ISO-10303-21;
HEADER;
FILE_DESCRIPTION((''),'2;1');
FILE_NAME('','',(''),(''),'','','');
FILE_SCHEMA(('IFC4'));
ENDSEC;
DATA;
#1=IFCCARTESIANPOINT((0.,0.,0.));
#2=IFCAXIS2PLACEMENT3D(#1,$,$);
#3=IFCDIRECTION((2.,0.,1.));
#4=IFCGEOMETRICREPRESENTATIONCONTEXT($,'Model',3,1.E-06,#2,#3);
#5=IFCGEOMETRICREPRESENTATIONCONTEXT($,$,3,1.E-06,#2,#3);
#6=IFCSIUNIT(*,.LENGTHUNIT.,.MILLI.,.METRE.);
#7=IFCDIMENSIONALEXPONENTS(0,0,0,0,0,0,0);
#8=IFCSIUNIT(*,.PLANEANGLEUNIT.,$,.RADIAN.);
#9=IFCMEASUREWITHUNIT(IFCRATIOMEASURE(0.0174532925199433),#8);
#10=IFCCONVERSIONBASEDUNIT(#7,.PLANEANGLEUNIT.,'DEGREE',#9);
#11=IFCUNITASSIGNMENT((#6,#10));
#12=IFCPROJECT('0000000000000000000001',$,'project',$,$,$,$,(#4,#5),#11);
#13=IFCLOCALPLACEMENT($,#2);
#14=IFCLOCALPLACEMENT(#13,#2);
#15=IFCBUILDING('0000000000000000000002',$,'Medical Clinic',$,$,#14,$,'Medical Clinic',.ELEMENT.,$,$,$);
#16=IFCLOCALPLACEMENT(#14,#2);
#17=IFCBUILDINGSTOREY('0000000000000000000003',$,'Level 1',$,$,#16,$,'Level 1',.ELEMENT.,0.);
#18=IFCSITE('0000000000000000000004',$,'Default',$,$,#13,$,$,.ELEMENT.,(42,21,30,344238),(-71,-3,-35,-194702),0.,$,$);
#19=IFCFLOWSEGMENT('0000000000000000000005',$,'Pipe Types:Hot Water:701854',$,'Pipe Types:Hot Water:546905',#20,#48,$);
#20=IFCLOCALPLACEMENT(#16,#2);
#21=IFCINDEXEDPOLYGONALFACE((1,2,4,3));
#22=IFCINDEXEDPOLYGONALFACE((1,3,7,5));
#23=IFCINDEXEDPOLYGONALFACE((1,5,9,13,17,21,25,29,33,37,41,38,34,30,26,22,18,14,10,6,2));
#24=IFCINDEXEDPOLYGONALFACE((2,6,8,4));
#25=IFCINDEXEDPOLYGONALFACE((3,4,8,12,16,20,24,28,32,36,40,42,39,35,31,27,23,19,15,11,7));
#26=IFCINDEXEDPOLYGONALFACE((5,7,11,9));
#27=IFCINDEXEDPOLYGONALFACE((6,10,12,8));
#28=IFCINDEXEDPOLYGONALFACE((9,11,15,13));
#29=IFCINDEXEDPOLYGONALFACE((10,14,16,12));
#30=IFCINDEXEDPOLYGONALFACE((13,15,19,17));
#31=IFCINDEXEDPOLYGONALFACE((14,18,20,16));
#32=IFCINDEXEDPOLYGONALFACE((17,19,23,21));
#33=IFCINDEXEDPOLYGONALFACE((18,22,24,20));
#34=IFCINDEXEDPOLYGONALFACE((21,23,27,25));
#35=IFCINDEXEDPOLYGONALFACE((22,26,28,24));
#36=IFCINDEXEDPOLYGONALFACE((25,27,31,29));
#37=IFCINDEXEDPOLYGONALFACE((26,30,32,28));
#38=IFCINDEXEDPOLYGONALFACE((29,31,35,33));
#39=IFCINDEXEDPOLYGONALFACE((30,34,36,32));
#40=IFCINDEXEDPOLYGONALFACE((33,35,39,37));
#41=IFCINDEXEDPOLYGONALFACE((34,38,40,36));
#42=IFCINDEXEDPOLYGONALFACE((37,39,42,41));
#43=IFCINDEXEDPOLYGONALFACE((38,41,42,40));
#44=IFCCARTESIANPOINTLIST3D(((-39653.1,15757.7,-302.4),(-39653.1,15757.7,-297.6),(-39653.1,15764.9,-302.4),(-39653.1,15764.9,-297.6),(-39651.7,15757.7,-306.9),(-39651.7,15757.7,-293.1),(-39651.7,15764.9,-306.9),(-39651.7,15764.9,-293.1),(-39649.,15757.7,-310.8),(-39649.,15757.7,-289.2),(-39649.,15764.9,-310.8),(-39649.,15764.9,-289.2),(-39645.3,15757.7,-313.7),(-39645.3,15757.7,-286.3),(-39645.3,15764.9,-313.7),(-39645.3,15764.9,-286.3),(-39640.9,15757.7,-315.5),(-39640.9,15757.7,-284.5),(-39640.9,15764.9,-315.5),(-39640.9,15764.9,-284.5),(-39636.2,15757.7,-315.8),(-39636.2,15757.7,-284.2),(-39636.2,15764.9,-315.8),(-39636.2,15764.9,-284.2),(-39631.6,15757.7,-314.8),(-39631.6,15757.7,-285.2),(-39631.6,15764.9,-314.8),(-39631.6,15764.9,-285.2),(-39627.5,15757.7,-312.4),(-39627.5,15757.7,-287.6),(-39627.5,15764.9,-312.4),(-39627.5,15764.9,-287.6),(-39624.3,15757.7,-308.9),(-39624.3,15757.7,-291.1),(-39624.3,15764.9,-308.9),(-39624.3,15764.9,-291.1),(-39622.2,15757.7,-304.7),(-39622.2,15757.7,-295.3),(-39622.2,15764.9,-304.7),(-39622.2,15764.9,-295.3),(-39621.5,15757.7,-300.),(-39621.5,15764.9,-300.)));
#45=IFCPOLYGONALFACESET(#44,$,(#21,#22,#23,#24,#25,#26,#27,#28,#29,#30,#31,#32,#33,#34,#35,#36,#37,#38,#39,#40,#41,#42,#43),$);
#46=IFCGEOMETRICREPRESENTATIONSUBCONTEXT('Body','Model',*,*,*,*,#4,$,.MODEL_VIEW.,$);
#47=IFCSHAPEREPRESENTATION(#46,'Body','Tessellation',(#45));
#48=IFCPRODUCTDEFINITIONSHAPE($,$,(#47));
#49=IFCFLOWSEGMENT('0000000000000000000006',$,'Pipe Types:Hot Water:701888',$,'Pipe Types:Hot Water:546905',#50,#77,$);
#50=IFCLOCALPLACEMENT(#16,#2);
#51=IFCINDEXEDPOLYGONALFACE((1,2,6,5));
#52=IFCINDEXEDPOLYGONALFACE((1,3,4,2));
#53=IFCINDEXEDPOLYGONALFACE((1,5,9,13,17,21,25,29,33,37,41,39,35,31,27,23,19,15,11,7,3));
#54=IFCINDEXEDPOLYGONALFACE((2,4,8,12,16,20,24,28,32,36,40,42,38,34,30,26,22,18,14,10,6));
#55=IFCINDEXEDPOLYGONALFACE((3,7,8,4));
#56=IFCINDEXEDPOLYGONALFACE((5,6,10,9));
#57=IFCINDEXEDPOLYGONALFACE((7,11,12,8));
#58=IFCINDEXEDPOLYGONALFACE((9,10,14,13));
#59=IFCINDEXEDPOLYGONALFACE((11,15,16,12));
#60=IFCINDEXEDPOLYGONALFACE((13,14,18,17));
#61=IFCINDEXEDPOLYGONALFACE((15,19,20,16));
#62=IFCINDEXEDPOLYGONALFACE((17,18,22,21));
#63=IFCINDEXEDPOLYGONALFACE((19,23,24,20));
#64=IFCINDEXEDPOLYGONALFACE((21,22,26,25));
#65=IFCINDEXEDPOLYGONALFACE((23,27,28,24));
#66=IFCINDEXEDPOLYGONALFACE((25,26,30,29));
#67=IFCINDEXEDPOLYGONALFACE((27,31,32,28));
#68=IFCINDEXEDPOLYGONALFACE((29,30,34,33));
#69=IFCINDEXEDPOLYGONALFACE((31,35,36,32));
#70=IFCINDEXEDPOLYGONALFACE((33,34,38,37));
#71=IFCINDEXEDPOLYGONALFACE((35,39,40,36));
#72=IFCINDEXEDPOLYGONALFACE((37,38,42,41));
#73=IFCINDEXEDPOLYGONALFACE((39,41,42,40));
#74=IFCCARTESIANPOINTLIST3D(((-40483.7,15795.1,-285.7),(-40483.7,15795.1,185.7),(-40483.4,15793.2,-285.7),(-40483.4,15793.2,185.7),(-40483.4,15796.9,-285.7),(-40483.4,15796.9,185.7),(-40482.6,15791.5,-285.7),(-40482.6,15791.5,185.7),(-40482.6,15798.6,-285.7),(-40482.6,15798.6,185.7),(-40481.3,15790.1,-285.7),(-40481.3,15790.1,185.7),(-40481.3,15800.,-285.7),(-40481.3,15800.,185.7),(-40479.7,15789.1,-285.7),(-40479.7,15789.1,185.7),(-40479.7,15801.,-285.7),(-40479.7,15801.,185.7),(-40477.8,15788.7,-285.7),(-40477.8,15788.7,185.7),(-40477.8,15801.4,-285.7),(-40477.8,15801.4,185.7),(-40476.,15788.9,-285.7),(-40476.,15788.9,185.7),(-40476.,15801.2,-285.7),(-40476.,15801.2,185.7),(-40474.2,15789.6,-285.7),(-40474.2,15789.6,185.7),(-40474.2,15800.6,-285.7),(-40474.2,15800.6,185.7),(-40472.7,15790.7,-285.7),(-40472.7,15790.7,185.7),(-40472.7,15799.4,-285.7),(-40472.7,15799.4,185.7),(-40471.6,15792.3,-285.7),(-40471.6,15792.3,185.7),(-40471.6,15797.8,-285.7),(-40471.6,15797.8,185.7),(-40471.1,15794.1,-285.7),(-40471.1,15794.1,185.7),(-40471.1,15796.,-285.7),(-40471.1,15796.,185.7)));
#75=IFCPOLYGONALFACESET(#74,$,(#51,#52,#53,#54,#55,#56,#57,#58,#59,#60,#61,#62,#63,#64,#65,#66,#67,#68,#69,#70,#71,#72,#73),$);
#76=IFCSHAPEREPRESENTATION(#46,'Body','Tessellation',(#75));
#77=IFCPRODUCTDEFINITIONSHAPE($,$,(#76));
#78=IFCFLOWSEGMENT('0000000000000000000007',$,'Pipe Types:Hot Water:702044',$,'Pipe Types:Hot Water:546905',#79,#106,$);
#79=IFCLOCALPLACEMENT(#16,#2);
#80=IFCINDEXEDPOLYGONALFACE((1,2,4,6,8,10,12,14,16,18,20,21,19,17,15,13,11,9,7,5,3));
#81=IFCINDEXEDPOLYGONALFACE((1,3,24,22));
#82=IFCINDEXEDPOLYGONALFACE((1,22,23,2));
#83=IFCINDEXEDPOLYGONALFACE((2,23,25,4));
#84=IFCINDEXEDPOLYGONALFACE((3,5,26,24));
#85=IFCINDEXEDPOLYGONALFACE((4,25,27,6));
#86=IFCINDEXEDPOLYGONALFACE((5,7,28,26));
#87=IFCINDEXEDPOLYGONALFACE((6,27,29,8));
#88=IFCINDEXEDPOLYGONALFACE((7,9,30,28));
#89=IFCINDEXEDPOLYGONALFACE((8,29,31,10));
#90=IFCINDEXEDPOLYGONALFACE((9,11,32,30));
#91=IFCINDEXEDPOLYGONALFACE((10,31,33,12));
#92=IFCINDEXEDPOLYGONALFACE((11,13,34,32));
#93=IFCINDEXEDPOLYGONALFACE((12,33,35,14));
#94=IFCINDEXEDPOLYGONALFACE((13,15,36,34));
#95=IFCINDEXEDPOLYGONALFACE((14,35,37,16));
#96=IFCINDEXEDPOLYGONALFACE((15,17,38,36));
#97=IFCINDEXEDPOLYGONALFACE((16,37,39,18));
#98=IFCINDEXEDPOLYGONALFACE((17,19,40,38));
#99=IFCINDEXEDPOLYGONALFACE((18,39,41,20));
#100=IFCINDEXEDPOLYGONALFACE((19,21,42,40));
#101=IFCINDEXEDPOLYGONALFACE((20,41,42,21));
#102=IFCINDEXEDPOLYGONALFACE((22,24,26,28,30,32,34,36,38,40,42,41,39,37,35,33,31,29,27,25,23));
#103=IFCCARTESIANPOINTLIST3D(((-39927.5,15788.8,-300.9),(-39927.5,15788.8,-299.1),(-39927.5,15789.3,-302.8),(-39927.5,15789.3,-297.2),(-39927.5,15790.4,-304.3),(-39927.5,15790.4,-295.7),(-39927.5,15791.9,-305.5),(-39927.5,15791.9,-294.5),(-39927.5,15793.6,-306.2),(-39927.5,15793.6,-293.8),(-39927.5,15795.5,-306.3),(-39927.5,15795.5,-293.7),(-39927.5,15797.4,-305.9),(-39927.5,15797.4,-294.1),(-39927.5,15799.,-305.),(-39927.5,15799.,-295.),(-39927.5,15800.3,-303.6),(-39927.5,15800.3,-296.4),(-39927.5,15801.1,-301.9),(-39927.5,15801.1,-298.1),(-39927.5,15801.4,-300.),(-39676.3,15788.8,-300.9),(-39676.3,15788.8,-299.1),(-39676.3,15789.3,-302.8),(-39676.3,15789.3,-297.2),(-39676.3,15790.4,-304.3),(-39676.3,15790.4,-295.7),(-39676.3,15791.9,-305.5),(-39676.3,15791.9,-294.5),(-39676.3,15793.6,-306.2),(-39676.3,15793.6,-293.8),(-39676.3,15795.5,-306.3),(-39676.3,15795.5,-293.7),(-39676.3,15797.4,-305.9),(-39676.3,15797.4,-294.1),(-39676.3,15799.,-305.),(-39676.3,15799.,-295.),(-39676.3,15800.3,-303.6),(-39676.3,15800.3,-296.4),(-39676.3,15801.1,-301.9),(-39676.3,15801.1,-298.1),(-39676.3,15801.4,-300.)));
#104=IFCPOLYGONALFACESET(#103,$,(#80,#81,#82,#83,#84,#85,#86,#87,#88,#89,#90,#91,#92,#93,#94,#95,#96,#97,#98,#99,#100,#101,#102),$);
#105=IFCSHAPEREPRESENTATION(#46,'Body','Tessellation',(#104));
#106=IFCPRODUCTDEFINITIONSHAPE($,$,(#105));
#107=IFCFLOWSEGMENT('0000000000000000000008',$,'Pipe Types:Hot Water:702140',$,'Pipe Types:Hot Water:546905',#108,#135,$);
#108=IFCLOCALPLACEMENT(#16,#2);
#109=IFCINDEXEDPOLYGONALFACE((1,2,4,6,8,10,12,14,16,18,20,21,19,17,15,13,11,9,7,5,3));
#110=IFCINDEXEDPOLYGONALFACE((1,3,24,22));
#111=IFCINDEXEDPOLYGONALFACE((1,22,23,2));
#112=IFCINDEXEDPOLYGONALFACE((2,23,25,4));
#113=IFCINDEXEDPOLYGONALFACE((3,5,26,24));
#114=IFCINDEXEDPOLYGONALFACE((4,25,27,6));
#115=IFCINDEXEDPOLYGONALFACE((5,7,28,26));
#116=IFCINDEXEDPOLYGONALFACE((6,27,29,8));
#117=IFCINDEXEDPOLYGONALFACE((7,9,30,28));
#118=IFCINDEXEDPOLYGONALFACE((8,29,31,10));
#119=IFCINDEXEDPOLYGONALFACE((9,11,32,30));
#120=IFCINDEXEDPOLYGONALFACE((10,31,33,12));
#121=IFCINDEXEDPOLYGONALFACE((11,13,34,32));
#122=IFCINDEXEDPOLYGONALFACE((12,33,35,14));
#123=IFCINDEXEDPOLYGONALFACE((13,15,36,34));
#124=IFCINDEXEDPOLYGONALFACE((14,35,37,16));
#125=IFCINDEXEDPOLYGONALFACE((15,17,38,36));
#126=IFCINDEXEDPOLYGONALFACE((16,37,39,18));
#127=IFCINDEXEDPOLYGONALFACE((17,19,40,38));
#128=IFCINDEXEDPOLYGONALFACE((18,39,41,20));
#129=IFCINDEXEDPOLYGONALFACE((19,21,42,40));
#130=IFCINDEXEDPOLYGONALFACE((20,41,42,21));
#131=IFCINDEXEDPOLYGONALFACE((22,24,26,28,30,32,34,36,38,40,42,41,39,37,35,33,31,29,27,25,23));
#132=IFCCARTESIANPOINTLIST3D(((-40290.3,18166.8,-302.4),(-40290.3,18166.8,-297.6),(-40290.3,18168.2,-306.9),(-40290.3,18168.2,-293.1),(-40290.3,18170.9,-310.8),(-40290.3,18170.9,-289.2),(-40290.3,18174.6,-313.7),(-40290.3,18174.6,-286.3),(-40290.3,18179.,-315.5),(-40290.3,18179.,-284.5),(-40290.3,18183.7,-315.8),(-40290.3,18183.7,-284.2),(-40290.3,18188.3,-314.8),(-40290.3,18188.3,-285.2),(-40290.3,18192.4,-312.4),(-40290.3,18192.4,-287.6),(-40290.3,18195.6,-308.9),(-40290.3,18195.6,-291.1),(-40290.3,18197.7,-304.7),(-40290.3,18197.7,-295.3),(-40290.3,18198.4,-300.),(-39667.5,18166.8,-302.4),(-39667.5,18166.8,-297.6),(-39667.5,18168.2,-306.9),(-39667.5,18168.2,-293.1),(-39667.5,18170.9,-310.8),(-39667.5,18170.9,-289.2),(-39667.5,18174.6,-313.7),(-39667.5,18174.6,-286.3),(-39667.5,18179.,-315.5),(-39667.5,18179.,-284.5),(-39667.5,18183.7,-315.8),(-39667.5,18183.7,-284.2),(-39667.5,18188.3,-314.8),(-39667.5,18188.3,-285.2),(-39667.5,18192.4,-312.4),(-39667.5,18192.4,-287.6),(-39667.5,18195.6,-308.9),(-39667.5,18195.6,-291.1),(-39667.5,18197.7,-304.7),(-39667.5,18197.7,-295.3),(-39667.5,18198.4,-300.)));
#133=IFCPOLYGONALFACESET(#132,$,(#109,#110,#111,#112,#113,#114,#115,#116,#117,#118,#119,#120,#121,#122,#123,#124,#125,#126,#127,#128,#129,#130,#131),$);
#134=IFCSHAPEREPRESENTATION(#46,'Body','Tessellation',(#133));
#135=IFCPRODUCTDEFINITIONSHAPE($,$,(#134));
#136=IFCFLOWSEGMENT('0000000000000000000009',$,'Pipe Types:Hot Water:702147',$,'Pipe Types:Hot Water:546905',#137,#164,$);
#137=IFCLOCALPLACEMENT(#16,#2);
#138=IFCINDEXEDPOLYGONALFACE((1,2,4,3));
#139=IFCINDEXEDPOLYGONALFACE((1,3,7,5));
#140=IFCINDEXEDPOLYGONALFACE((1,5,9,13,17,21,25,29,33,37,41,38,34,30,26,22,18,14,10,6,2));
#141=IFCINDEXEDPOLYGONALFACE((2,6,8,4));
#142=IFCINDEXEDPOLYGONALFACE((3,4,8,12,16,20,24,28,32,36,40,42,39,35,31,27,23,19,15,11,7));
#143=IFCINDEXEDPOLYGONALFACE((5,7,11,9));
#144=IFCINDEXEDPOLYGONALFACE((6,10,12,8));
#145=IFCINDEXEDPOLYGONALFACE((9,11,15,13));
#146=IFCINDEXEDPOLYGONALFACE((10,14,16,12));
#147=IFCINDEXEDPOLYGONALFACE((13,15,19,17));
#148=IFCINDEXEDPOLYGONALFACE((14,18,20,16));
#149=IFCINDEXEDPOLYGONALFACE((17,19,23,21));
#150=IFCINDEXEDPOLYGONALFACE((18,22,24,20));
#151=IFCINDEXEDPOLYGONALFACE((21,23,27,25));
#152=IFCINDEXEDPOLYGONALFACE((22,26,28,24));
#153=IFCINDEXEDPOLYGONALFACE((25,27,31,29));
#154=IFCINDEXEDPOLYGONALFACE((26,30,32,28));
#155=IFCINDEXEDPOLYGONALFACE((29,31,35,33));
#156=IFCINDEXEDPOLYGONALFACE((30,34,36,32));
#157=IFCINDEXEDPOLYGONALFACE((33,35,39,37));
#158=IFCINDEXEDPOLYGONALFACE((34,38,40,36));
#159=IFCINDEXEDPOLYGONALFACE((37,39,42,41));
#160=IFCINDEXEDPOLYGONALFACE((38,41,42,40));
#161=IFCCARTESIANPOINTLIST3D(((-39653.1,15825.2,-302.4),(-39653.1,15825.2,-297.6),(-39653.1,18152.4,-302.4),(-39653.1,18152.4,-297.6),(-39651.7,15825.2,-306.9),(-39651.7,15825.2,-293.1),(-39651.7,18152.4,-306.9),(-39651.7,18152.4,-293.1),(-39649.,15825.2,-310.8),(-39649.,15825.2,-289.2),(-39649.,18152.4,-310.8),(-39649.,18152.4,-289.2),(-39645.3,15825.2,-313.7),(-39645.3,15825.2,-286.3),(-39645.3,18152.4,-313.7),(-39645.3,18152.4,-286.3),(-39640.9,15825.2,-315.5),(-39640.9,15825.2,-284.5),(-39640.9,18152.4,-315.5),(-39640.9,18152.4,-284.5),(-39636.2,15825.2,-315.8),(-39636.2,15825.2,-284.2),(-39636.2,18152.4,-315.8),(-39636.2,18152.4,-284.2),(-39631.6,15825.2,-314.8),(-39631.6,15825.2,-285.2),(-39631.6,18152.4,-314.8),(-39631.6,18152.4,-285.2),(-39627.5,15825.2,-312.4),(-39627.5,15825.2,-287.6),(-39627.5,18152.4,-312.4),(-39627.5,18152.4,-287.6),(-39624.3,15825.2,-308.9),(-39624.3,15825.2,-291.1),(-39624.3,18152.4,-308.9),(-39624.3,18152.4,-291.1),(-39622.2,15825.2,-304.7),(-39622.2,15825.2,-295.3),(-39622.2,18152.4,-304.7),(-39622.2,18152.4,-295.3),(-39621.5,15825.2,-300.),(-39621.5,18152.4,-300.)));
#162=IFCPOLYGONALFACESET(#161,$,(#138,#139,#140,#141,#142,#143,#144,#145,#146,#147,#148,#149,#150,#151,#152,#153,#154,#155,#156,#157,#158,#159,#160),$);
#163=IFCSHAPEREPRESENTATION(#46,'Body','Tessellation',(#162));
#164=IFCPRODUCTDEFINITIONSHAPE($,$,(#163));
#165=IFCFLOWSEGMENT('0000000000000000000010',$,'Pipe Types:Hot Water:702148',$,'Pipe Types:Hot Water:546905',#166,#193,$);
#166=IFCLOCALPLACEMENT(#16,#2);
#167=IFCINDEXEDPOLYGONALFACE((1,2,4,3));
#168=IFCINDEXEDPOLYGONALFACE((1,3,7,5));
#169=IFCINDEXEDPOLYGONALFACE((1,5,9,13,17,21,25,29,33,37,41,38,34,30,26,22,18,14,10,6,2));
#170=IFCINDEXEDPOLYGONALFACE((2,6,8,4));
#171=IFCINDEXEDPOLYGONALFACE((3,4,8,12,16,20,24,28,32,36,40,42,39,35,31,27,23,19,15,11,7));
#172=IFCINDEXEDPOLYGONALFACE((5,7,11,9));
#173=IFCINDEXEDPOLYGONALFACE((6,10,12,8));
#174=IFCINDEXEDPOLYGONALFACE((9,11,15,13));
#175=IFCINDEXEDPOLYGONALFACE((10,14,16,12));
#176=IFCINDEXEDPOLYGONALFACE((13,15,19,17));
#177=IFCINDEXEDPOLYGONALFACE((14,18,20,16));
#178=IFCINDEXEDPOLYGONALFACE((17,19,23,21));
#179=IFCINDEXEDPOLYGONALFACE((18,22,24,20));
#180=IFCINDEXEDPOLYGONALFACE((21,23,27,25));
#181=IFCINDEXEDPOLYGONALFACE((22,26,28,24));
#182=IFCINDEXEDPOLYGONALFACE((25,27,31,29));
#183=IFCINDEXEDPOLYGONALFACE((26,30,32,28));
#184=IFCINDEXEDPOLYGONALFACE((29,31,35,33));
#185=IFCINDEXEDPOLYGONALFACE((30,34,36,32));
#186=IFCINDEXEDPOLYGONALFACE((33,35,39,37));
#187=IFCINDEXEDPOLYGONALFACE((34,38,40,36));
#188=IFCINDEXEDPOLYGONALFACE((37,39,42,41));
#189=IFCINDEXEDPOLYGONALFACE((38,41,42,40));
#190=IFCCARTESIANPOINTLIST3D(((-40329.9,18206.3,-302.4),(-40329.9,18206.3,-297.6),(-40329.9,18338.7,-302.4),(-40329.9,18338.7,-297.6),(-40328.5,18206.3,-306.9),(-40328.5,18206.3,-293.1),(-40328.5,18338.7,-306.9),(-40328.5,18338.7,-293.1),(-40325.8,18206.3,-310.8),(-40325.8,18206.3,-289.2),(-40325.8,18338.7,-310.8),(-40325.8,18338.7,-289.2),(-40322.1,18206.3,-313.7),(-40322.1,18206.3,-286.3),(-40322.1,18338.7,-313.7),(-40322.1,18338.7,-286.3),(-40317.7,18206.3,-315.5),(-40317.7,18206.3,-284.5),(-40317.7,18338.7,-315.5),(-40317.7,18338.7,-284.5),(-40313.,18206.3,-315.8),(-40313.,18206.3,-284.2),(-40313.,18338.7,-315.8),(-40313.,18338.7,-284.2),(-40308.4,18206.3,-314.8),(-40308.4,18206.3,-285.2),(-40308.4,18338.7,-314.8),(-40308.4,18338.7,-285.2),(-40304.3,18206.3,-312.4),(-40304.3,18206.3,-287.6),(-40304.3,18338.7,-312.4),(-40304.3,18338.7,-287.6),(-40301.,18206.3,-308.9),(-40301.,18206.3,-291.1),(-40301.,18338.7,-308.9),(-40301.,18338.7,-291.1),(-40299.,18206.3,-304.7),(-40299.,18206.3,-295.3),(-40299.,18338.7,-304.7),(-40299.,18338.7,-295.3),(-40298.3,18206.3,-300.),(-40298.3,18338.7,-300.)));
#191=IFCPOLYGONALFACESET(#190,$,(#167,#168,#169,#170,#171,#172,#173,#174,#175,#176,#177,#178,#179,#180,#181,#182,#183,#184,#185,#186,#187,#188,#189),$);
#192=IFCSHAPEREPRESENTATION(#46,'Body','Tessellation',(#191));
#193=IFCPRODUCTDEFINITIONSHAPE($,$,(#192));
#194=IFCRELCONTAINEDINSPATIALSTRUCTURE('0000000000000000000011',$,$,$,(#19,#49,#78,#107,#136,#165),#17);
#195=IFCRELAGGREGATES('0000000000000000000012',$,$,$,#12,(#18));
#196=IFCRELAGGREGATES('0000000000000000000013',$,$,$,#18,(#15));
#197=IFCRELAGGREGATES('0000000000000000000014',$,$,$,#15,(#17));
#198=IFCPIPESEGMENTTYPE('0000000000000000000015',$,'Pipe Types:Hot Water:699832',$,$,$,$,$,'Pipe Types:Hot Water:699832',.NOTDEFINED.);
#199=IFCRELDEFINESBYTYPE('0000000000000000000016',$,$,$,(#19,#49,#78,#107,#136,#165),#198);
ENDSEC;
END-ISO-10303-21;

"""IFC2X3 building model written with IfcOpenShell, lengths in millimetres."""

from ifc_helpers import new_model, entity, si_unit, converted_unit, direction, frame, frame_2d, origin, origin_2d_with_axis, place, context, subcontext, project, spatial, circle, extrude, type_object, element, save


model = new_model("IFC2X3")

# Units and contexts
model_context = context("Model", 3, precision=1e-06, world=origin(), true_north=direction((2.0, 0.0, 1.0)))
context_of_model = context(None, 3, precision=1e-06, world=origin(), true_north=direction((2.0, 0.0, 1.0)))
body_context = subcontext(model_context, "Body", "Model", "MODEL_VIEW")
ifc_project = project(units=[si_unit("LENGTHUNIT", "METRE", prefix="MILLI"), converted_unit("PLANEANGLEUNIT", "DEGREE", entity("IfcRatioMeasure", 0.0174532925199433), si_unit("PLANEANGLEUNIT", "RADIAN"), dimensions=[0, 0, 0, 0, 0, 0, 0])], contexts=[model_context, context_of_model])

# Site, building, storey
site_placement = place(None, origin())
site = spatial("IfcSite", under=ifc_project, at=site_placement, Name="Default", CompositionType="ELEMENT", RefLatitude=(42, 21, 30, 344238), RefLongitude=(-71, -3, -35, -194702), RefElevation=0.0)
building_placement = place(site_placement, origin())
building = spatial("IfcBuilding", under=site, at=building_placement, Name="Medical Clinic", LongName="Medical Clinic", CompositionType="ELEMENT")
storey_placement = place(building_placement, origin())
storey = spatial("IfcBuildingStorey", under=building, at=storey_placement, Name="Level 1", LongName="Level 1", CompositionType="ELEMENT", Elevation=0.0)

# Flow segments
pipe_segment_type_1 = type_object("IfcPipeSegmentType", Name="Pipe Types:Hot Water:699832", ElementType="Pipe Types:Hot Water:699832", PredefinedType="NOTDEFINED")
flow_segment_1_placement = place(storey_placement, origin())
element("IfcFlowSegment", 1, at=flow_segment_1_placement, inside=storey, type_object=pipe_segment_type_1, Name="Pipe Types:Hot Water:701854", ObjectType="Pipe Types:Hot Water:546905", context=body_context, shape_type="SweptSolid", body=[
    extrude(circle(Radius=15.9, at=frame_2d((0.0, 0.0), x_axis=(1.0, 0.0))), frame((-39637.4, 15757.7, -300.0), z_axis=(0.0, 1.0, 0.0), x_axis=(1.0, 0.0, 0.0)), (0.0, 0.0, 1.0), 7.2),
])
flow_segment_2_placement = place(storey_placement, origin())
element("IfcFlowSegment", 2, at=flow_segment_2_placement, inside=storey, type_object=pipe_segment_type_1, Name="Pipe Types:Hot Water:701888", ObjectType="Pipe Types:Hot Water:546905", context=body_context, shape_type="SweptSolid", body=[
    extrude(circle(Radius=6.3, at=origin_2d_with_axis()), frame((-40477.4, 15795.1, -285.7), z_axis=(0.0, 0.0, 1.0), x_axis=(-1.0, 0.0, 0.0)), (0.0, 0.0, 1.0), 471.4),
])
flow_segment_3_placement = place(storey_placement, origin())
element("IfcFlowSegment", 3, at=flow_segment_3_placement, inside=storey, type_object=pipe_segment_type_1, Name="Pipe Types:Hot Water:702044", ObjectType="Pipe Types:Hot Water:546905", context=body_context, shape_type="SweptSolid", body=[
    extrude(circle(Radius=6.3, at=frame_2d((0.0, 0.0), x_axis=(1.0, 0.0))), frame((-39927.5, 15795.1, -300.0), z_axis=(1.0, 0.0, 0.0), x_axis=(0.0, 1.0, 0.0)), (0.0, 0.0, 1.0), 251.2),
])
flow_segment_4_placement = place(storey_placement, origin())
element("IfcFlowSegment", 4, at=flow_segment_4_placement, inside=storey, type_object=pipe_segment_type_1, Name="Pipe Types:Hot Water:702140", ObjectType="Pipe Types:Hot Water:546905", context=body_context, shape_type="SweptSolid", body=[
    extrude(circle(Radius=15.9, at=frame_2d((0.0, 0.0), x_axis=(1.0, 0.0))), frame((-40290.3, 18182.5, -300.0), z_axis=(1.0, 0.0, 0.0), x_axis=(0.0, 1.0, 0.0)), (0.0, 0.0, 1.0), 622.8),
])
flow_segment_5_placement = place(storey_placement, origin())
element("IfcFlowSegment", 5, at=flow_segment_5_placement, inside=storey, type_object=pipe_segment_type_1, Name="Pipe Types:Hot Water:702147", ObjectType="Pipe Types:Hot Water:546905", context=body_context, shape_type="SweptSolid", body=[
    extrude(circle(Radius=15.9, at=origin_2d_with_axis()), frame((-39637.4, 15825.2, -300.0), z_axis=(0.0, 1.0, 0.0), x_axis=(1.0, 0.0, 0.0)), (0.0, 0.0, 1.0), 2327.1),
])
flow_segment_6_placement = place(storey_placement, origin())
element("IfcFlowSegment", 6, at=flow_segment_6_placement, inside=storey, type_object=pipe_segment_type_1, Name="Pipe Types:Hot Water:702148", ObjectType="Pipe Types:Hot Water:546905", context=body_context, shape_type="SweptSolid", body=[
    extrude(circle(Radius=15.9, at=frame_2d((0.0, 0.0), x_axis=(1.0, 0.0))), frame((-40314.2, 18206.3, -300.0), z_axis=(0.0, 1.0, 0.0), x_axis=(1.0, 0.0, 0.0)), (0.0, 0.0, 1.0), 132.4),
])

save(model, "model.ifc")
